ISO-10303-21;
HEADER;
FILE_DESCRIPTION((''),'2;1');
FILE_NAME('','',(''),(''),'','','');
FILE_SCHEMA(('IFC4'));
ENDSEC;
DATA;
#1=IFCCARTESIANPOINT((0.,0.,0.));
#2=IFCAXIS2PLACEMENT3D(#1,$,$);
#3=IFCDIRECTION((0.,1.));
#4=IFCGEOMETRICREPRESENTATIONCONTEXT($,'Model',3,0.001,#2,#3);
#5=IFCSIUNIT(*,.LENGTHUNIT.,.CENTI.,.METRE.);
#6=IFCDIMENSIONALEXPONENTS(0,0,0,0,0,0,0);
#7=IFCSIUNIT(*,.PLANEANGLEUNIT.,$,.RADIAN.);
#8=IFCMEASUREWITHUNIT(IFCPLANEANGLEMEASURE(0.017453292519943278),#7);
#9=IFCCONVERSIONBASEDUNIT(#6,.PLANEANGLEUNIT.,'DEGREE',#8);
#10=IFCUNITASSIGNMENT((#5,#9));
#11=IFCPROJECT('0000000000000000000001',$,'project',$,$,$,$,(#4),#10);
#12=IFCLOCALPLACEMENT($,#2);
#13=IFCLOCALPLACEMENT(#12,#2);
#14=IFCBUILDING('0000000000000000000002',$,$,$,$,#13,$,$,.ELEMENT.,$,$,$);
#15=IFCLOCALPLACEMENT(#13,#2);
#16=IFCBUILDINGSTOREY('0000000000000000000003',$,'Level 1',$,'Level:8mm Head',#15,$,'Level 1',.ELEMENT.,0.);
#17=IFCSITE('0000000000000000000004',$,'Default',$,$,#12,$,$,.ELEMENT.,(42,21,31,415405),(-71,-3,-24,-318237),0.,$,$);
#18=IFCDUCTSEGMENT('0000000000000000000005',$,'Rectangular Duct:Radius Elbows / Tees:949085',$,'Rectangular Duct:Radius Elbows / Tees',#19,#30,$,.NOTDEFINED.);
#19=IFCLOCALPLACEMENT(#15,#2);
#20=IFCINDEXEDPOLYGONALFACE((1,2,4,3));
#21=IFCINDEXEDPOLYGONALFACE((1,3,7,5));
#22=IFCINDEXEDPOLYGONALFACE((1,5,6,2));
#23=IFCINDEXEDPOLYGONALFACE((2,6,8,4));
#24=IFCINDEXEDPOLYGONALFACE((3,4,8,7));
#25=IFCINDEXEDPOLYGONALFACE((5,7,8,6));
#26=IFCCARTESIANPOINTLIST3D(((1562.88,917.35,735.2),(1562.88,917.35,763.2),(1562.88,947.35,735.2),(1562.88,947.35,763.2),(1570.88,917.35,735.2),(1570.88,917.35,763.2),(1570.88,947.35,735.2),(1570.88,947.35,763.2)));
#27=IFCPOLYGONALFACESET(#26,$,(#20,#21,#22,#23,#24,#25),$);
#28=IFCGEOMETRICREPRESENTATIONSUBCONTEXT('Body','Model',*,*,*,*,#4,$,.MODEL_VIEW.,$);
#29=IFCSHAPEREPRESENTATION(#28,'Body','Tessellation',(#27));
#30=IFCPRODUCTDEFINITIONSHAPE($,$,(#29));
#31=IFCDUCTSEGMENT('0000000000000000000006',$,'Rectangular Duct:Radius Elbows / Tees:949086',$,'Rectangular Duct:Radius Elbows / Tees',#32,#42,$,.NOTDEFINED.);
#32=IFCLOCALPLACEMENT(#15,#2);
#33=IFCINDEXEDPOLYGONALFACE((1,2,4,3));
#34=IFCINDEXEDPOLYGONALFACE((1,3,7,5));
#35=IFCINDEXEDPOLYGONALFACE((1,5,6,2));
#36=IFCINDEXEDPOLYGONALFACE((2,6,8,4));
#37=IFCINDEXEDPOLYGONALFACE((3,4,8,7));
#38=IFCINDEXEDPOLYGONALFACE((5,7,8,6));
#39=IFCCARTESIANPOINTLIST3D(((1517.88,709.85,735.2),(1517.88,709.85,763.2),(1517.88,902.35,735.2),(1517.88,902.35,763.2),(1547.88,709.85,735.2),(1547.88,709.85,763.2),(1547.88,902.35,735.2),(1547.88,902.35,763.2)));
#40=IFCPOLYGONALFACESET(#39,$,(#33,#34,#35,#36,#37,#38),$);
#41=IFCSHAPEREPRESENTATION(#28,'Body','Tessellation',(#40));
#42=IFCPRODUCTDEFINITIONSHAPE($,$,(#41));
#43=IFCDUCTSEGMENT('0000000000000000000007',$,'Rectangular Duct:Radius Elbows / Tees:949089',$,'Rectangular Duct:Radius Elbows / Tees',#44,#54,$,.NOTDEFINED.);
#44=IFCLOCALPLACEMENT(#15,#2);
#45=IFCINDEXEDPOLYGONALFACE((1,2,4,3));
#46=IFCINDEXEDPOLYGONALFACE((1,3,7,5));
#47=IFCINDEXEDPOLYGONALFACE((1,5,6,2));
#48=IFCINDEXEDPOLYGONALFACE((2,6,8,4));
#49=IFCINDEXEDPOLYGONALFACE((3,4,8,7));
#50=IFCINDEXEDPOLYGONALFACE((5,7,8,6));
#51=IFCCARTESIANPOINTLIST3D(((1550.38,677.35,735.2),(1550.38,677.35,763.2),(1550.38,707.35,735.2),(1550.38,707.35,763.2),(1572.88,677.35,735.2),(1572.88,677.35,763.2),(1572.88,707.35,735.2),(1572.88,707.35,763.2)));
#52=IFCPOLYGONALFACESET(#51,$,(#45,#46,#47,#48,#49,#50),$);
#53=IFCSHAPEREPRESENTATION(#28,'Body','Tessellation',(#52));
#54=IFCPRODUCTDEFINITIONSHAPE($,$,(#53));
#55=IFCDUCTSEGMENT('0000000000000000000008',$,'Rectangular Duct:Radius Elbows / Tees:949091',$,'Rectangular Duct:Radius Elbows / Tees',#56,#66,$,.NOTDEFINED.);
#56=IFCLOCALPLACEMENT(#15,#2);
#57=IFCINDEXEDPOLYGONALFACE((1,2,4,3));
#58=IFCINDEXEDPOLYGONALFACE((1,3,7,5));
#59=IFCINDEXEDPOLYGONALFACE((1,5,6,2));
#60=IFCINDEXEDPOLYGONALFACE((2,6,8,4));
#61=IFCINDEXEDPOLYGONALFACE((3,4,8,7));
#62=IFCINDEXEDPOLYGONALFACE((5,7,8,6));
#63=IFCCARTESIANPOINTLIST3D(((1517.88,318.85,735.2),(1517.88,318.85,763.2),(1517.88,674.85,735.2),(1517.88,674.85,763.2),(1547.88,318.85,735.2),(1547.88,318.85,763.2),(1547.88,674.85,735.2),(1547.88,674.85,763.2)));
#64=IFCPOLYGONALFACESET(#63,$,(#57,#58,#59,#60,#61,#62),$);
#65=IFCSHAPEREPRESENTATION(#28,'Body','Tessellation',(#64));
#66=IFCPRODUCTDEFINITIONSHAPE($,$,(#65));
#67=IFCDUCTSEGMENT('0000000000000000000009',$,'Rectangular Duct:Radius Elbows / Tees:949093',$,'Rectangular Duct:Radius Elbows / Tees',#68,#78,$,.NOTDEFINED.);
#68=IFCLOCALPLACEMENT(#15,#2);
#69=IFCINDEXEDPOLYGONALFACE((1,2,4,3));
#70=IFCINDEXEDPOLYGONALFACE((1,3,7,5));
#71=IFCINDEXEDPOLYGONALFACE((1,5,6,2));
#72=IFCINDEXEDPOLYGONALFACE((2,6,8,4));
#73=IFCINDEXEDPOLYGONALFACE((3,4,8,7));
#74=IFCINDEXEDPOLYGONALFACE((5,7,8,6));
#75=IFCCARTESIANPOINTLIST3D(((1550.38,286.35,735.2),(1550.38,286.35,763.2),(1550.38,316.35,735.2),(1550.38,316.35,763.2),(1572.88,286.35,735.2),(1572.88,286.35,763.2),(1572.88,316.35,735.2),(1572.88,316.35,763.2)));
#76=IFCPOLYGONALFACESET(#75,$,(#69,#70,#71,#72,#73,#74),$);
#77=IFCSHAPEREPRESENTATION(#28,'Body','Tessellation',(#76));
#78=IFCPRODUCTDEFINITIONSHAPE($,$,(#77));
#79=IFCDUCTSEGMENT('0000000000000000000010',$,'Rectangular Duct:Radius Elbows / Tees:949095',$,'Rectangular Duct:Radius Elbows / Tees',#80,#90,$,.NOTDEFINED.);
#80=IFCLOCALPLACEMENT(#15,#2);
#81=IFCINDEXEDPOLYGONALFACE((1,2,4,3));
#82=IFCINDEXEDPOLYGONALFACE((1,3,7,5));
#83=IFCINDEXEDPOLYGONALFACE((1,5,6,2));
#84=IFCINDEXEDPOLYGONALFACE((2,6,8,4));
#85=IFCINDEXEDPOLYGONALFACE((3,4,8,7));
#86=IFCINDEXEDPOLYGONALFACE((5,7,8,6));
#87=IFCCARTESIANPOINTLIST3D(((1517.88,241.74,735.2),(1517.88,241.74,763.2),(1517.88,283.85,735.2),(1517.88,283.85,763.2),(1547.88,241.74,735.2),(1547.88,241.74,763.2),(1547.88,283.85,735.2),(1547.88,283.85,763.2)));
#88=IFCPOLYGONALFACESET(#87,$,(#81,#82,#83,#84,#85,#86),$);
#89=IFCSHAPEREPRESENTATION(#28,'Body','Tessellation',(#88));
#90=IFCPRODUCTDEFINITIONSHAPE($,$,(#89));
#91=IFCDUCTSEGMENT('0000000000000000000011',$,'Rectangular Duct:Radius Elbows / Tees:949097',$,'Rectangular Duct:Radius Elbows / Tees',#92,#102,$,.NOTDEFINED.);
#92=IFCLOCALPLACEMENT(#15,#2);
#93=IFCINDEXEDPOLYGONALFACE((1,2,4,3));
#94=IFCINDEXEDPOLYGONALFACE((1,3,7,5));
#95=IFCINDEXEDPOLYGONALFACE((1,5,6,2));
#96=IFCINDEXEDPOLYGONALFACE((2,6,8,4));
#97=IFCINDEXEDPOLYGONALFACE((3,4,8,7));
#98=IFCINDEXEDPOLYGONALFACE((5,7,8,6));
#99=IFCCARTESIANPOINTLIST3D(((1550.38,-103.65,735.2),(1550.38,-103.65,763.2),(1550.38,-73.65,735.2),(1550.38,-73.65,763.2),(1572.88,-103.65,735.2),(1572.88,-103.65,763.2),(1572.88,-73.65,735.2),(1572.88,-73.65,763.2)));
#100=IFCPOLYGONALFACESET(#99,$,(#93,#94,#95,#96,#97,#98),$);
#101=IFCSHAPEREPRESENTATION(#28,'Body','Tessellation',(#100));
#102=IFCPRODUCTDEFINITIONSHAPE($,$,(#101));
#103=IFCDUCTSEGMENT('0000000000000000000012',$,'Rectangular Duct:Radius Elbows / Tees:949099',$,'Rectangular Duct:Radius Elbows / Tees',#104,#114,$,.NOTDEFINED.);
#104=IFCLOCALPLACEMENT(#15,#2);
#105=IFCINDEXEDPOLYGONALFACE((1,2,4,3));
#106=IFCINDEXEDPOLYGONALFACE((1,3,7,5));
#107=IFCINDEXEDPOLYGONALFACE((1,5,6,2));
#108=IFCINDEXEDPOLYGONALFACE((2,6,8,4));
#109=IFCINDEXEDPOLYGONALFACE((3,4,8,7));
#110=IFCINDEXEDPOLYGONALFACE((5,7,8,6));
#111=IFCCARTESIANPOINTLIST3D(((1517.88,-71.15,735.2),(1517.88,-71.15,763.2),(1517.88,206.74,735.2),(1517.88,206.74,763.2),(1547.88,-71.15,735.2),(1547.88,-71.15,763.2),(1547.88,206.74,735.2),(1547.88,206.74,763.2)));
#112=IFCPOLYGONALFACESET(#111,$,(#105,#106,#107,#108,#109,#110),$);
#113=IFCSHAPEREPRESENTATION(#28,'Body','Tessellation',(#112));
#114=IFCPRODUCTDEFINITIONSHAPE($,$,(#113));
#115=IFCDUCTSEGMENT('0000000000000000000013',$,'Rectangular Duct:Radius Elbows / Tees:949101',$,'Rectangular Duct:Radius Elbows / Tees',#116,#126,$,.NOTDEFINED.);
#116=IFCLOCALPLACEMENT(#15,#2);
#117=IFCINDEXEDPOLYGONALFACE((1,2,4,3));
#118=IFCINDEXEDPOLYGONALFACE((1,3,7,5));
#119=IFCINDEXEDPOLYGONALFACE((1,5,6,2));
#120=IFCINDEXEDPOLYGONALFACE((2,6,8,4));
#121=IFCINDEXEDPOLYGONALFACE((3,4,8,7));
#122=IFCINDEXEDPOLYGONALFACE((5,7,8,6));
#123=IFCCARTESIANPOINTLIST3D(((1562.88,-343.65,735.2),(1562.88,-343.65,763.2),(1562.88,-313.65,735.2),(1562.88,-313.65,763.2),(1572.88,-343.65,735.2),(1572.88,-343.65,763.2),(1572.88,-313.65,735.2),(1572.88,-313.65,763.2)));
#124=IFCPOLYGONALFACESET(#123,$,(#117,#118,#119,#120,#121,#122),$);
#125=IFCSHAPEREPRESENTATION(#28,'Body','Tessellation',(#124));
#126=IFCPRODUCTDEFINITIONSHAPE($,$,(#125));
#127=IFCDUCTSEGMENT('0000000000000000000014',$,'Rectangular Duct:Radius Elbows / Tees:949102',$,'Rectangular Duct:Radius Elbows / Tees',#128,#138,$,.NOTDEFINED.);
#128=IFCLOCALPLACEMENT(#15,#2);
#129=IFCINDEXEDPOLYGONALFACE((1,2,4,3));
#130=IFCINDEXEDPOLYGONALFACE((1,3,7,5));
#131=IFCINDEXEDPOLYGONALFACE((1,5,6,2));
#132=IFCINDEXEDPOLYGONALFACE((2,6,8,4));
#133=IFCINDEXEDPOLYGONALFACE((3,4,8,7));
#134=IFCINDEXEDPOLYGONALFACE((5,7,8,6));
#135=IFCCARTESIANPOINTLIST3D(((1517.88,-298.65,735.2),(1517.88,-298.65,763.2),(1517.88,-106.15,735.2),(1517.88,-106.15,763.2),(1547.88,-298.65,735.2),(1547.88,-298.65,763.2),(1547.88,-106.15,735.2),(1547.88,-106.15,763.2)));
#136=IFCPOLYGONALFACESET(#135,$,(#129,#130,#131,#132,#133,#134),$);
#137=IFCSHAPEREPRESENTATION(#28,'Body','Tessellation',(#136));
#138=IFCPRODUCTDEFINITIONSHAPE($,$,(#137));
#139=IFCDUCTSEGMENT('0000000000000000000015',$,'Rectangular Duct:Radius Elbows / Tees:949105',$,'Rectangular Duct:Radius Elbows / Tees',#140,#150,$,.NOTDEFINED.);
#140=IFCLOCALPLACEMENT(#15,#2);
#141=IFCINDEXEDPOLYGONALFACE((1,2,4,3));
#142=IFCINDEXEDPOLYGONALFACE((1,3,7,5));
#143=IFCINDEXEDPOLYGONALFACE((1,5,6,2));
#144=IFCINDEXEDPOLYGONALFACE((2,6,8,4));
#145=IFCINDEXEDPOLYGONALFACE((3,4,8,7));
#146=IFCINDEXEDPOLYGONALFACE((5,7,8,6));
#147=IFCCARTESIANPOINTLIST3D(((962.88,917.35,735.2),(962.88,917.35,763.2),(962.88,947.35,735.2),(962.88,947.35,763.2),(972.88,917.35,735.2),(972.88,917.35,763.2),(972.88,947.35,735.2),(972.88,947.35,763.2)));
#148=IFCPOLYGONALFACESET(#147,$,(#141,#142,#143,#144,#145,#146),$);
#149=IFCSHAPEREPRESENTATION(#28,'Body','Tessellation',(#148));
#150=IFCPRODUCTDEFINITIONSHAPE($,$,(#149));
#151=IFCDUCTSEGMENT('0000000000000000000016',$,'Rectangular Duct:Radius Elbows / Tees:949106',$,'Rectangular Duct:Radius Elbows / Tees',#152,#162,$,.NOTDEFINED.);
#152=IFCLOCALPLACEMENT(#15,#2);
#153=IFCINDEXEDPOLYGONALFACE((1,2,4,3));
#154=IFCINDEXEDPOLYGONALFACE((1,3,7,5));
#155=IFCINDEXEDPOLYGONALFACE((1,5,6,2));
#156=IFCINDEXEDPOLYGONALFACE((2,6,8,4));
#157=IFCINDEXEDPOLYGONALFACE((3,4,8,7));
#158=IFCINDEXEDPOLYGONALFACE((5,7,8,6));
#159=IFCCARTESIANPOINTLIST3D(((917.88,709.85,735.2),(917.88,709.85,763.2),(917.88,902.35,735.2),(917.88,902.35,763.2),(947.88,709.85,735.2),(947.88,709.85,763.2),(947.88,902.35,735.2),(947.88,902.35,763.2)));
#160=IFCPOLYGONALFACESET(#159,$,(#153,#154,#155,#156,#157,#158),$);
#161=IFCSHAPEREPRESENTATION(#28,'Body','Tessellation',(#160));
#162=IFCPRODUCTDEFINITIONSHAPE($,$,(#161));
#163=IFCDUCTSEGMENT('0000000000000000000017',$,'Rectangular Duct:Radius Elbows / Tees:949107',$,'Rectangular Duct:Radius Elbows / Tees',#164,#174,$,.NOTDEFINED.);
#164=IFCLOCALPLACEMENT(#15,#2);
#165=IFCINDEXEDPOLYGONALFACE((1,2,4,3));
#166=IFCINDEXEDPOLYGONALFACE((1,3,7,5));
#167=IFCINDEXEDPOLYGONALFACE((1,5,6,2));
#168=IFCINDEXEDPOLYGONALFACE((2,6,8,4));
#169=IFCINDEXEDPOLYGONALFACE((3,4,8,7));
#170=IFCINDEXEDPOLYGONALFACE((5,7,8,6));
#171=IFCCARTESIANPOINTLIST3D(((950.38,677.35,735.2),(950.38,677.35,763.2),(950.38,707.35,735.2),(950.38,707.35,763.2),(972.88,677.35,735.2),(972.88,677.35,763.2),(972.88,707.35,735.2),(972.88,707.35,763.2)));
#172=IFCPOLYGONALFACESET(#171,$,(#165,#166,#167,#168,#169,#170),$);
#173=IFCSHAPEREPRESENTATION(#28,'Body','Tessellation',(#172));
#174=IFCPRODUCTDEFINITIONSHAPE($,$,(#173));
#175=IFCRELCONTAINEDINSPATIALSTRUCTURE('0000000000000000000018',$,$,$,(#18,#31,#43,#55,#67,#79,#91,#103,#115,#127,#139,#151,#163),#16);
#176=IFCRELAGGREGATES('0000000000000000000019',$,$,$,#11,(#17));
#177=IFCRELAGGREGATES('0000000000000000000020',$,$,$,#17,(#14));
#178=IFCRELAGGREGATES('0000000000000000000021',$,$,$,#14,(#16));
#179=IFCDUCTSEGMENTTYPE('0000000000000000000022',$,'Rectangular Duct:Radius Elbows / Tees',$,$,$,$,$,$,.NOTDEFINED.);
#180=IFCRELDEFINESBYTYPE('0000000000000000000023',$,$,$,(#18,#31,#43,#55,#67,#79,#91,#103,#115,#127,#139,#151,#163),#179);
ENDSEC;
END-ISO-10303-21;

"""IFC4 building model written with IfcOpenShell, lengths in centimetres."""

from ifc_helpers import new_model, entity, si_unit, converted_unit, direction, frame, origin, place, context, subcontext, project, spatial, indexed_curve, outline, extrude, type_object, element, save


model = new_model("IFC4")

# Units and contexts
model_context = context("Model", 3, precision=0.001, world=origin(), true_north=direction((0.0, 1.0)))
body_context = subcontext(model_context, "Body", "Model", "MODEL_VIEW")
ifc_project = project(units=[si_unit("LENGTHUNIT", "METRE", prefix="CENTI"), converted_unit("PLANEANGLEUNIT", "DEGREE", entity("IfcPlaneAngleMeasure", 0.017453292519943278), si_unit("PLANEANGLEUNIT", "RADIAN"), dimensions=[0, 0, 0, 0, 0, 0, 0])], contexts=[model_context])

# Site, building, storey
site_placement = place(None, origin())
site = spatial("IfcSite", under=ifc_project, at=site_placement, Name="Default", CompositionType="ELEMENT", RefLatitude=(42, 21, 31, 415405), RefLongitude=(-71, -3, -24, -318237), RefElevation=0.0)
building_placement = place(site_placement, origin())
building = spatial("IfcBuilding", under=site, at=building_placement, CompositionType="ELEMENT")
storey_placement = place(building_placement, origin())
storey = spatial("IfcBuildingStorey", under=building, at=storey_placement, Name="Level 1", ObjectType="Level:8mm Head", LongName="Level 1", CompositionType="ELEMENT", Elevation=0.0)

# Duct segments
duct_segment_type = type_object("IfcDuctSegmentType", Name="Rectangular Duct:Radius Elbows / Tees", PredefinedType="NOTDEFINED")
duct_segment_1_placement = place(storey_placement, origin())
element("IfcDuctSegment", 1, at=duct_segment_1_placement, inside=storey, type_object=duct_segment_type, Name="Rectangular Duct:Radius Elbows / Tees:949085", ObjectType="Rectangular Duct:Radius Elbows / Tees", PredefinedType="NOTDEFINED", context=body_context, shape_type="SweptSolid", body=[
    extrude(outline(indexed_curve([(-4.0, -15.0), (4.0, -15.0), (4.0, 15.0), (-4.0, 15.0), (-4.0, -15.0)], self_intersect=False)), frame((1566.88, 932.35, 735.2)), (0.0, 0.0, 1.0), 28.0),
])
duct_segment_2_placement = place(storey_placement, origin())
element("IfcDuctSegment", 2, at=duct_segment_2_placement, inside=storey, type_object=duct_segment_type, Name="Rectangular Duct:Radius Elbows / Tees:949086", ObjectType="Rectangular Duct:Radius Elbows / Tees", PredefinedType="NOTDEFINED", context=body_context, shape_type="SweptSolid", body=[
    extrude(outline(indexed_curve([(-96.25, -15.0), (96.25, -15.0), (96.25, 15.0), (-96.25, 15.0), (-96.25, -15.0)], self_intersect=False)), frame((1532.88, 806.1, 735.2), z_axis=(0.0, 0.0, 1.0), x_axis=(0.0, 1.0, 0.0)), (0.0, 0.0, 1.0), 28.0),
])
duct_segment_3_placement = place(storey_placement, origin())
element("IfcDuctSegment", 3, at=duct_segment_3_placement, inside=storey, type_object=duct_segment_type, Name="Rectangular Duct:Radius Elbows / Tees:949089", ObjectType="Rectangular Duct:Radius Elbows / Tees", PredefinedType="NOTDEFINED", context=body_context, shape_type="SweptSolid", body=[
    extrude(outline(indexed_curve([(-11.25, -15.0), (11.25, -15.0), (11.25, 15.0), (-11.25, 15.0), (-11.25, -15.0)], self_intersect=False)), frame((1561.63, 692.35, 735.2)), (0.0, 0.0, 1.0), 28.0),
])
duct_segment_4_placement = place(storey_placement, origin())
element("IfcDuctSegment", 4, at=duct_segment_4_placement, inside=storey, type_object=duct_segment_type, Name="Rectangular Duct:Radius Elbows / Tees:949091", ObjectType="Rectangular Duct:Radius Elbows / Tees", PredefinedType="NOTDEFINED", context=body_context, shape_type="SweptSolid", body=[
    extrude(outline(indexed_curve([(-178.0, -15.0), (178.0, -15.0), (178.0, 15.0), (-178.0, 15.0), (-178.0, -15.0)], self_intersect=False)), frame((1532.88, 496.85, 735.2), z_axis=(0.0, 0.0, 1.0), x_axis=(0.0, 1.0, 0.0)), (0.0, 0.0, 1.0), 28.0),
])
duct_segment_5_placement = place(storey_placement, origin())
element("IfcDuctSegment", 5, at=duct_segment_5_placement, inside=storey, type_object=duct_segment_type, Name="Rectangular Duct:Radius Elbows / Tees:949093", ObjectType="Rectangular Duct:Radius Elbows / Tees", PredefinedType="NOTDEFINED", context=body_context, shape_type="SweptSolid", body=[
    extrude(outline(indexed_curve([(-11.25, -15.0), (11.25, -15.0), (11.25, 15.0), (-11.25, 15.0), (-11.25, -15.0)], self_intersect=False)), frame((1561.63, 301.35, 735.2)), (0.0, 0.0, 1.0), 28.0),
])
duct_segment_6_placement = place(storey_placement, origin())
element("IfcDuctSegment", 6, at=duct_segment_6_placement, inside=storey, type_object=duct_segment_type, Name="Rectangular Duct:Radius Elbows / Tees:949095", ObjectType="Rectangular Duct:Radius Elbows / Tees", PredefinedType="NOTDEFINED", context=body_context, shape_type="SweptSolid", body=[
    extrude(outline(indexed_curve([(-21.05, -15.0), (21.05, -15.0), (21.05, 15.0), (-21.05, 15.0), (-21.05, -15.0)], self_intersect=False)), frame((1532.88, 262.79, 735.2), z_axis=(0.0, 0.0, 1.0), x_axis=(0.0, 1.0, 0.0)), (0.0, 0.0, 1.0), 28.0),
])
duct_segment_7_placement = place(storey_placement, origin())
element("IfcDuctSegment", 7, at=duct_segment_7_placement, inside=storey, type_object=duct_segment_type, Name="Rectangular Duct:Radius Elbows / Tees:949097", ObjectType="Rectangular Duct:Radius Elbows / Tees", PredefinedType="NOTDEFINED", context=body_context, shape_type="SweptSolid", body=[
    extrude(outline(indexed_curve([(-11.25, -15.0), (11.25, -15.0), (11.25, 15.0), (-11.25, 15.0), (-11.25, -15.0)], self_intersect=False)), frame((1561.63, -88.65, 735.2)), (0.0, 0.0, 1.0), 28.0),
])
duct_segment_8_placement = place(storey_placement, origin())
element("IfcDuctSegment", 8, at=duct_segment_8_placement, inside=storey, type_object=duct_segment_type, Name="Rectangular Duct:Radius Elbows / Tees:949099", ObjectType="Rectangular Duct:Radius Elbows / Tees", PredefinedType="NOTDEFINED", context=body_context, shape_type="SweptSolid", body=[
    extrude(outline(indexed_curve([(-138.95, -15.0), (138.95, -15.0), (138.95, 15.0), (-138.95, 15.0), (-138.95, -15.0)], self_intersect=False)), frame((1532.88, 67.79, 735.2), z_axis=(0.0, 0.0, 1.0), x_axis=(0.0, -1.0, 0.0)), (0.0, 0.0, 1.0), 28.0),
])
duct_segment_9_placement = place(storey_placement, origin())
element("IfcDuctSegment", 9, at=duct_segment_9_placement, inside=storey, type_object=duct_segment_type, Name="Rectangular Duct:Radius Elbows / Tees:949101", ObjectType="Rectangular Duct:Radius Elbows / Tees", PredefinedType="NOTDEFINED", context=body_context, shape_type="SweptSolid", body=[
    extrude(outline(indexed_curve([(-5.0, -15.0), (5.0, -15.0), (5.0, 15.0), (-5.0, 15.0), (-5.0, -15.0)], self_intersect=False)), frame((1567.88, -328.65, 735.2)), (0.0, 0.0, 1.0), 28.0),
])
duct_segment_10_placement = place(storey_placement, origin())
element("IfcDuctSegment", 10, at=duct_segment_10_placement, inside=storey, type_object=duct_segment_type, Name="Rectangular Duct:Radius Elbows / Tees:949102", ObjectType="Rectangular Duct:Radius Elbows / Tees", PredefinedType="NOTDEFINED", context=body_context, shape_type="SweptSolid", body=[
    extrude(outline(indexed_curve([(-96.25, -15.0), (96.25, -15.0), (96.25, 15.0), (-96.25, 15.0), (-96.25, -15.0)], self_intersect=False)), frame((1532.88, -202.4, 735.2), z_axis=(0.0, 0.0, 1.0), x_axis=(0.0, -1.0, 0.0)), (0.0, 0.0, 1.0), 28.0),
])
duct_segment_11_placement = place(storey_placement, origin())
element("IfcDuctSegment", 11, at=duct_segment_11_placement, inside=storey, type_object=duct_segment_type, Name="Rectangular Duct:Radius Elbows / Tees:949105", ObjectType="Rectangular Duct:Radius Elbows / Tees", PredefinedType="NOTDEFINED", context=body_context, shape_type="SweptSolid", body=[
    extrude(outline(indexed_curve([(-5.0, -15.0), (5.0, -15.0), (5.0, 15.0), (-5.0, 15.0), (-5.0, -15.0)], self_intersect=False)), frame((967.88, 932.35, 735.2)), (0.0, 0.0, 1.0), 28.0),
])
duct_segment_12_placement = place(storey_placement, origin())
element("IfcDuctSegment", 12, at=duct_segment_12_placement, inside=storey, type_object=duct_segment_type, Name="Rectangular Duct:Radius Elbows / Tees:949106", ObjectType="Rectangular Duct:Radius Elbows / Tees", PredefinedType="NOTDEFINED", context=body_context, shape_type="SweptSolid", body=[
    extrude(outline(indexed_curve([(-96.25, -15.0), (96.25, -15.0), (96.25, 15.0), (-96.25, 15.0), (-96.25, -15.0)], self_intersect=False)), frame((932.88, 806.1, 735.2), z_axis=(0.0, 0.0, 1.0), x_axis=(0.0, 1.0, 0.0)), (0.0, 0.0, 1.0), 28.0),
])
duct_segment_13_placement = place(storey_placement, origin())
element("IfcDuctSegment", 13, at=duct_segment_13_placement, inside=storey, type_object=duct_segment_type, Name="Rectangular Duct:Radius Elbows / Tees:949107", ObjectType="Rectangular Duct:Radius Elbows / Tees", PredefinedType="NOTDEFINED", context=body_context, shape_type="SweptSolid", body=[
    extrude(outline(indexed_curve([(-11.25, -15.0), (11.25, -15.0), (11.25, 15.0), (-11.25, 15.0), (-11.25, -15.0)], self_intersect=False)), frame((961.63, 692.35, 735.2)), (0.0, 0.0, 1.0), 28.0),
])

save(model, "model.ifc")
